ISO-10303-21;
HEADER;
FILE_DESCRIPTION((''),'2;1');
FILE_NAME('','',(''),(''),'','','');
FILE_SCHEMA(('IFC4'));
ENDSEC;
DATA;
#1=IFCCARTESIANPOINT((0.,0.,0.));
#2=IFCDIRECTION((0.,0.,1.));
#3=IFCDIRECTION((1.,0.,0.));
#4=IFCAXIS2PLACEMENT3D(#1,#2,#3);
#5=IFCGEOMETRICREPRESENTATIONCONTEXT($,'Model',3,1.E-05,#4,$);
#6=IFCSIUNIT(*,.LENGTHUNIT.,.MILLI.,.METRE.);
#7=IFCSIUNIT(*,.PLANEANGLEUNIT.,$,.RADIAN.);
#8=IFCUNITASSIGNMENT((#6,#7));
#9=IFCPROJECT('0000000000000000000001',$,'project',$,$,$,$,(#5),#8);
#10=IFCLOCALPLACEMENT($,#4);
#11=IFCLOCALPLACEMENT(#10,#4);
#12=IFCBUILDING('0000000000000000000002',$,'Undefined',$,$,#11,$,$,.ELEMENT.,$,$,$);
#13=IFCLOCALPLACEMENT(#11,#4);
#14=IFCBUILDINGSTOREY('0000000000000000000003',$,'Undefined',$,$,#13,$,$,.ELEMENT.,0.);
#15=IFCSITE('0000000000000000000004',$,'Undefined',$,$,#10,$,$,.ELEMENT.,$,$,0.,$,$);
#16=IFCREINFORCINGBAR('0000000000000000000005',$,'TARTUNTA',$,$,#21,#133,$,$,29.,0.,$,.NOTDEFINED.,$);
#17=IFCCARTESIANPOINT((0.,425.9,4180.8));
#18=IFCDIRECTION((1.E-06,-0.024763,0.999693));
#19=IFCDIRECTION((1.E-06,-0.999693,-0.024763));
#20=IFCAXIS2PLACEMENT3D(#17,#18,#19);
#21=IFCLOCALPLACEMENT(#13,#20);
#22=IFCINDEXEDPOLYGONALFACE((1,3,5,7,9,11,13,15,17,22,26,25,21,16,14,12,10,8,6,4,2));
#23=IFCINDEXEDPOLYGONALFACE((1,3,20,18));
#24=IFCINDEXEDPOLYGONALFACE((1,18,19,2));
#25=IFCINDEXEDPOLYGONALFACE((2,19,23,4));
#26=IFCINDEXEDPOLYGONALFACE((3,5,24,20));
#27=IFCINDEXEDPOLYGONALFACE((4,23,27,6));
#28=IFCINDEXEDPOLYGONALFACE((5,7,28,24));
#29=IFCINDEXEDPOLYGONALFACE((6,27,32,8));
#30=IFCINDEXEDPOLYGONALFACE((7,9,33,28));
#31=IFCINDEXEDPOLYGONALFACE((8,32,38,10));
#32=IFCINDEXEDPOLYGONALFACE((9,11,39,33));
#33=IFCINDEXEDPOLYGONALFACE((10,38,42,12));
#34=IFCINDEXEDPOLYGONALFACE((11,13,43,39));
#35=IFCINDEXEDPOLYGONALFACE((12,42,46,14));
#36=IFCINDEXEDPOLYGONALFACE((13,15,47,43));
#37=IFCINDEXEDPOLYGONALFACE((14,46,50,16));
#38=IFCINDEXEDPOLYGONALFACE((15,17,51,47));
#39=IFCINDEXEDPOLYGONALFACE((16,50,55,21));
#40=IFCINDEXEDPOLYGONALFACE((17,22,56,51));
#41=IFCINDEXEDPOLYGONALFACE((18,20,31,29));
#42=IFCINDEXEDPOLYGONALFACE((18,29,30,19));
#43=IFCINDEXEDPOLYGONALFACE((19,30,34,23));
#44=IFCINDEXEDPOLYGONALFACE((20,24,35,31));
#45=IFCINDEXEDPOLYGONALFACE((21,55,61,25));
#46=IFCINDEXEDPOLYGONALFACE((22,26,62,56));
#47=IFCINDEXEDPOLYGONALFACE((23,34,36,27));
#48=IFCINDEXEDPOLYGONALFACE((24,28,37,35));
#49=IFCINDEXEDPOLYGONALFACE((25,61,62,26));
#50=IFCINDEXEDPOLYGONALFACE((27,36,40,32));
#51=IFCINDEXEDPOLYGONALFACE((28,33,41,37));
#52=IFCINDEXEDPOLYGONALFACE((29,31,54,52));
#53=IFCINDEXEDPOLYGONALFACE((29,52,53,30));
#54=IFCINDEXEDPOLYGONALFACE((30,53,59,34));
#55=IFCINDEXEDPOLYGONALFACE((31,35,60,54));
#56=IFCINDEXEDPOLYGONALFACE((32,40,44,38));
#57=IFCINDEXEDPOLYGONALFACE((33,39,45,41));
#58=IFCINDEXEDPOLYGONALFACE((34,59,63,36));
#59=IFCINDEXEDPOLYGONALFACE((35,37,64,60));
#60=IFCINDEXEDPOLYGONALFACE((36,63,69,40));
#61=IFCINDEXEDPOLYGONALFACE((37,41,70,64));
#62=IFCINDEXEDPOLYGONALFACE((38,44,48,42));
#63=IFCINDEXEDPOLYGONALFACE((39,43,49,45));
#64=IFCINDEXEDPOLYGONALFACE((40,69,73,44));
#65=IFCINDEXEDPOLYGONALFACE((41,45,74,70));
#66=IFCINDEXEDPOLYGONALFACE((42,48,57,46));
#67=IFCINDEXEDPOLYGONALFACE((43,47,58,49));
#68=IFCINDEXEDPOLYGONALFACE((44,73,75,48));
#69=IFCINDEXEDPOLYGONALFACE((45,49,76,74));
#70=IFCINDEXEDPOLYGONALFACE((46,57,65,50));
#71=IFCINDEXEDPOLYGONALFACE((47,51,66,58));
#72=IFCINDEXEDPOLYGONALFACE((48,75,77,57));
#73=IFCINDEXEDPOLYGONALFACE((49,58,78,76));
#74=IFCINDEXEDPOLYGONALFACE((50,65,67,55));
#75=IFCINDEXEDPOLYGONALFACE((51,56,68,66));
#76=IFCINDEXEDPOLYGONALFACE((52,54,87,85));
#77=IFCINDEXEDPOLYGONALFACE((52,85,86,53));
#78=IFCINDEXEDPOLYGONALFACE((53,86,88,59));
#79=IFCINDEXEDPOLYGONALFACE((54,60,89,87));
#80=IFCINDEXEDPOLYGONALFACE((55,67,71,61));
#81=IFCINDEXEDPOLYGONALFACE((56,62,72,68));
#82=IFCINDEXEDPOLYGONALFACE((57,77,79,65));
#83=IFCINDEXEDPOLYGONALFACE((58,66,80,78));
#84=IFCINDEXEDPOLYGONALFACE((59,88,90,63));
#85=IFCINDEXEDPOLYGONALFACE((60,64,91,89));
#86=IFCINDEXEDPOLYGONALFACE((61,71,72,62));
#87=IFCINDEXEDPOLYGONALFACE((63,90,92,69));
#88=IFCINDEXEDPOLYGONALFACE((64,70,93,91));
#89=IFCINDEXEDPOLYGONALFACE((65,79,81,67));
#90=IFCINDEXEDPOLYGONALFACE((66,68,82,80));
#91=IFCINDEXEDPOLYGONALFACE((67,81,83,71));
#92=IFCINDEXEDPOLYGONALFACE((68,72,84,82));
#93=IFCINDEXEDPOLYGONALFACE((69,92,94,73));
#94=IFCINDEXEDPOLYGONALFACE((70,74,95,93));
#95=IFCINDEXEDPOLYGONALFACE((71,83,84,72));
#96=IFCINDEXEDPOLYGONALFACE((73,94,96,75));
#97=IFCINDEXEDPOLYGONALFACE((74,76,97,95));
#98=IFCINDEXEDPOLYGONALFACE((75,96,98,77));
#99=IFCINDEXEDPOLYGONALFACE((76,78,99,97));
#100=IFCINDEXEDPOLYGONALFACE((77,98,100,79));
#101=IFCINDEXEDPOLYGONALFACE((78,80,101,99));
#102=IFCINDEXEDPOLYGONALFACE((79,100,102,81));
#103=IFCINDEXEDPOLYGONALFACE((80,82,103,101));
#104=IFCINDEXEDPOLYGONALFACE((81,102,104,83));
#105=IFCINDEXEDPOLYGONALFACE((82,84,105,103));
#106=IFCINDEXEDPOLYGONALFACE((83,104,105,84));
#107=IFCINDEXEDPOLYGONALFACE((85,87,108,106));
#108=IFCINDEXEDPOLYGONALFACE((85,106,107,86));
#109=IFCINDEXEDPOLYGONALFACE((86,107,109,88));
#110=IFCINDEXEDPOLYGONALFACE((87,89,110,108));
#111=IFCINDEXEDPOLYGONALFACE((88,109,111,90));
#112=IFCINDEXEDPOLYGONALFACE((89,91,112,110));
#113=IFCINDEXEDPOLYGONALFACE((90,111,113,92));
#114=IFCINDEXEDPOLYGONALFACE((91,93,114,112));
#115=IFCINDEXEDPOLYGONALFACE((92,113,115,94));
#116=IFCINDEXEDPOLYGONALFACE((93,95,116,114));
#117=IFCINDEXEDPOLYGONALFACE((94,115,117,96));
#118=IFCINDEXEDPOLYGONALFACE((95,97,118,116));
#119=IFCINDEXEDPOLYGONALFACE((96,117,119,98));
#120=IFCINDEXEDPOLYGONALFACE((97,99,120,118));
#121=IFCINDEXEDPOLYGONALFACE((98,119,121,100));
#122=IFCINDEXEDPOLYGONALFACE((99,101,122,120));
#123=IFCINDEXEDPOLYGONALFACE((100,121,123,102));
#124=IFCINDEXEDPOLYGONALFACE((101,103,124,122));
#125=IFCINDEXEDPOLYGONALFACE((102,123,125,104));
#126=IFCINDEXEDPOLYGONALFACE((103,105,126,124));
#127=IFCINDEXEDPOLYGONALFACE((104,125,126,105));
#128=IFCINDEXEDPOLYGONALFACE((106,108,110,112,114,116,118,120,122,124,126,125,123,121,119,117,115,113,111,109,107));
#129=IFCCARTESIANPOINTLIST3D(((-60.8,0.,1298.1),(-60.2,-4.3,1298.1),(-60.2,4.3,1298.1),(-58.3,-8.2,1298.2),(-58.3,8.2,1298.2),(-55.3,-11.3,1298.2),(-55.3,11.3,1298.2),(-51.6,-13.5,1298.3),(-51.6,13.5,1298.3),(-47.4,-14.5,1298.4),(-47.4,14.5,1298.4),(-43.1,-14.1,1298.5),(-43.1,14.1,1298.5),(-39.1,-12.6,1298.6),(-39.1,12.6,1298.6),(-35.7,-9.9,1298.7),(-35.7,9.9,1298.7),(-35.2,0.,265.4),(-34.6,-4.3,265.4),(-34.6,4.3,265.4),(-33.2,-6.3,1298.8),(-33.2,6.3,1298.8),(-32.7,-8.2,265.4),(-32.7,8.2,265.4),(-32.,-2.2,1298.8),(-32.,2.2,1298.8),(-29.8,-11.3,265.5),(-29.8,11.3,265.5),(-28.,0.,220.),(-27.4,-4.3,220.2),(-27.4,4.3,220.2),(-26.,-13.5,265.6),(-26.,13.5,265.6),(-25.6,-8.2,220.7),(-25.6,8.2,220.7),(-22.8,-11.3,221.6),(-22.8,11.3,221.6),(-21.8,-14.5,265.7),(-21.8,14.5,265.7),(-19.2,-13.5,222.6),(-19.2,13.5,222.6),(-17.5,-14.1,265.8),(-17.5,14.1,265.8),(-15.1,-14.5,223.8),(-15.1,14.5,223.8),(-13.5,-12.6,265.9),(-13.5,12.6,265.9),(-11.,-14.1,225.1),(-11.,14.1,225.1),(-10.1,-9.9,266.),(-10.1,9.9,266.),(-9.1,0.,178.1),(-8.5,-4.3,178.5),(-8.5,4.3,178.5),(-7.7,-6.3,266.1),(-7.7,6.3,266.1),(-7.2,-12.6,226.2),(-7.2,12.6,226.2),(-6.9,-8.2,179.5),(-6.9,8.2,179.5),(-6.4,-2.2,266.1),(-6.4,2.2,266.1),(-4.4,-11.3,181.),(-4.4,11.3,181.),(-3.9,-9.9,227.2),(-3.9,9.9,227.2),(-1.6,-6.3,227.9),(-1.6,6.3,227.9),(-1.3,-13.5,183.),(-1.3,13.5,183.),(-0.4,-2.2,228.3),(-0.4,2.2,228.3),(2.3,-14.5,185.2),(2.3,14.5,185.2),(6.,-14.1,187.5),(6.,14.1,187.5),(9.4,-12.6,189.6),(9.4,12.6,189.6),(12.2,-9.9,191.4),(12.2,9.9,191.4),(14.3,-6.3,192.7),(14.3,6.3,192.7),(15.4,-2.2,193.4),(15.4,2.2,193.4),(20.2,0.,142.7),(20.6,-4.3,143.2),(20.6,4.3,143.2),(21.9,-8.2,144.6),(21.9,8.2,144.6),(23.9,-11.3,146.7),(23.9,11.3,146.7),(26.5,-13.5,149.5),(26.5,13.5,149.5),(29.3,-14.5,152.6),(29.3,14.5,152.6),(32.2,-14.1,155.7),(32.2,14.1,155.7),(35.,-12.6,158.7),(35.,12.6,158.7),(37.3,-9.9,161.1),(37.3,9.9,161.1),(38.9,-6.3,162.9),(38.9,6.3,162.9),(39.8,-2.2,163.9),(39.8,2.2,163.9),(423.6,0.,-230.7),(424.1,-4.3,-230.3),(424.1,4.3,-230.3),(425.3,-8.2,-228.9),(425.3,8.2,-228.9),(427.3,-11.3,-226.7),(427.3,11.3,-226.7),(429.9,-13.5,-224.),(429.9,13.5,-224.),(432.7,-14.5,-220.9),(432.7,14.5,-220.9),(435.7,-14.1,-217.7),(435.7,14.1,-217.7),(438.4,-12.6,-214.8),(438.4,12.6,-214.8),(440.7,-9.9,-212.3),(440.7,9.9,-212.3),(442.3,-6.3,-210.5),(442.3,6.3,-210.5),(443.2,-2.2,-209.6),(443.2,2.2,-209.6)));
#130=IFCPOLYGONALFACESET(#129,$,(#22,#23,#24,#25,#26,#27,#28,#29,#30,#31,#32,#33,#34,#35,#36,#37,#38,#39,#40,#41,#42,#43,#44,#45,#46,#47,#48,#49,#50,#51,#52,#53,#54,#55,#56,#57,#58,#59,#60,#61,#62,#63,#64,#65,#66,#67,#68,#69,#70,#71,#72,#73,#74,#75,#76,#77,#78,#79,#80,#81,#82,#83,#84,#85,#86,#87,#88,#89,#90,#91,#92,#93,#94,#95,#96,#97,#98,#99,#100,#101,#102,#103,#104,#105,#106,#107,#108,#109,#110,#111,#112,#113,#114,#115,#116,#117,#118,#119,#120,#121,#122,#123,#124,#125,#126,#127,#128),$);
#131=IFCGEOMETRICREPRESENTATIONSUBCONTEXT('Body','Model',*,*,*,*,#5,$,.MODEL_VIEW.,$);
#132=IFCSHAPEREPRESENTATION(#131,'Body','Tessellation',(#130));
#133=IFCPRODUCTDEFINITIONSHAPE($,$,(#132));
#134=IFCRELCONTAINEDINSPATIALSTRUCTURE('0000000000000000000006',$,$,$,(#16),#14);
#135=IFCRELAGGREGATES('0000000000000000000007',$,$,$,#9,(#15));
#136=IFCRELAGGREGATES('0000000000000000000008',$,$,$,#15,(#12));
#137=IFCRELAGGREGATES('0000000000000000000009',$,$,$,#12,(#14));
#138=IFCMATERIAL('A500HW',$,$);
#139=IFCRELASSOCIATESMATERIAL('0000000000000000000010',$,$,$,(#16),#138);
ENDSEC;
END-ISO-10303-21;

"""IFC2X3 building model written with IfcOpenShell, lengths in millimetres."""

from ifc_helpers import new_model, entity, si_unit, frame, origin_with_axes, place, context, subcontext, project, spatial, source, transform, mapped, material, element, save


model = new_model("IFC2X3")

# Units and contexts
model_context = context("Model", 3, precision=1e-05, world=origin_with_axes())
body_context = subcontext(model_context, "Body", "Model", "MODEL_VIEW")
ifc_project = project(units=[si_unit("LENGTHUNIT", "METRE", prefix="MILLI"), si_unit("PLANEANGLEUNIT", "RADIAN")], contexts=[model_context])

# Site, building, storey
site_placement = place(None, origin_with_axes())
site = spatial("IfcSite", under=ifc_project, at=site_placement, Name="Undefined", CompositionType="ELEMENT", RefElevation=0.0)
building_placement = place(site_placement, origin_with_axes())
building = spatial("IfcBuilding", under=site, at=building_placement, Name="Undefined", CompositionType="ELEMENT")
storey_placement = place(building_placement, origin_with_axes())
storey = spatial("IfcBuildingStorey", under=building, at=storey_placement, Name="Undefined", CompositionType="ELEMENT", Elevation=0.0)

# Reinforcing bar
ifc_material_1 = material(Name="A500HW")
shared_shape_1 = source(origin_with_axes(), body_context, "Body", "AdvancedSweptSolid", [
    entity("IfcSweptDiskSolid", entity("IfcCompositeCurve", [entity("IfcCompositeCurveSegment", "CONTINUOUS", True, entity("IfcTrimmedCurve", entity("IfcLine", entity("IfcCartesianPoint", [0.0, 0.0, 0.0]), entity("IfcVector", entity("IfcDirection", [0.024764, 0.0, -0.999693]), 1.0)), [entity("IfcParameterValue", 0.0)], [entity("IfcParameterValue", 1033.051648)], True, "PARAMETER")), entity("IfcCompositeCurveSegment", "CONTINUOUS", True, entity("IfcTrimmedCurve", entity("IfcCircle", entity("IfcAxis2Placement3D", entity("IfcCartesianPoint", [184.0, 0.0, -1028.8]), entity("IfcDirection", [0.000002, -1.0, 0.0]), entity("IfcDirection", [-0.999693, -0.000002, -0.024764])), 158.5), [entity("IfcParameterValue", 0.0)], [entity("IfcParameterValue", 0.799175)], True, "PARAMETER")), entity("IfcCompositeCurveSegment", "DISCONTINUOUS", True, entity("IfcTrimmedCurve", entity("IfcLine", entity("IfcCartesianPoint", [76.4, 0.0, -1145.1]), entity("IfcVector", entity("IfcDirection", [0.733829, 0.000001, -0.679334]), 1.0)), [entity("IfcParameterValue", 0.0)], [entity("IfcParameterValue", 549.736541)], True, "PARAMETER"))], False), 14.5, None, 0.0, 1583.6),
])
reinforcing_bar_1_placement = place(storey_placement, frame((0.0, 425.9, 4180.8), z_axis=(0.000001, -0.024763, 0.999693), x_axis=(0.000001, -0.999693, -0.024763)))
element("IfcReinforcingBar", 1, at=reinforcing_bar_1_placement, inside=storey, material=ifc_material_1, Name="TARTUNTA", BarRole="NOTDEFINED", CrossSectionArea=0.0, NominalDiameter=29.0, context=body_context, shape_type="MappedRepresentation", body=[
    mapped(shared_shape_1, transform((-46.3, 0.0, 1298.5))),
])

save(model, "model.ifc")
